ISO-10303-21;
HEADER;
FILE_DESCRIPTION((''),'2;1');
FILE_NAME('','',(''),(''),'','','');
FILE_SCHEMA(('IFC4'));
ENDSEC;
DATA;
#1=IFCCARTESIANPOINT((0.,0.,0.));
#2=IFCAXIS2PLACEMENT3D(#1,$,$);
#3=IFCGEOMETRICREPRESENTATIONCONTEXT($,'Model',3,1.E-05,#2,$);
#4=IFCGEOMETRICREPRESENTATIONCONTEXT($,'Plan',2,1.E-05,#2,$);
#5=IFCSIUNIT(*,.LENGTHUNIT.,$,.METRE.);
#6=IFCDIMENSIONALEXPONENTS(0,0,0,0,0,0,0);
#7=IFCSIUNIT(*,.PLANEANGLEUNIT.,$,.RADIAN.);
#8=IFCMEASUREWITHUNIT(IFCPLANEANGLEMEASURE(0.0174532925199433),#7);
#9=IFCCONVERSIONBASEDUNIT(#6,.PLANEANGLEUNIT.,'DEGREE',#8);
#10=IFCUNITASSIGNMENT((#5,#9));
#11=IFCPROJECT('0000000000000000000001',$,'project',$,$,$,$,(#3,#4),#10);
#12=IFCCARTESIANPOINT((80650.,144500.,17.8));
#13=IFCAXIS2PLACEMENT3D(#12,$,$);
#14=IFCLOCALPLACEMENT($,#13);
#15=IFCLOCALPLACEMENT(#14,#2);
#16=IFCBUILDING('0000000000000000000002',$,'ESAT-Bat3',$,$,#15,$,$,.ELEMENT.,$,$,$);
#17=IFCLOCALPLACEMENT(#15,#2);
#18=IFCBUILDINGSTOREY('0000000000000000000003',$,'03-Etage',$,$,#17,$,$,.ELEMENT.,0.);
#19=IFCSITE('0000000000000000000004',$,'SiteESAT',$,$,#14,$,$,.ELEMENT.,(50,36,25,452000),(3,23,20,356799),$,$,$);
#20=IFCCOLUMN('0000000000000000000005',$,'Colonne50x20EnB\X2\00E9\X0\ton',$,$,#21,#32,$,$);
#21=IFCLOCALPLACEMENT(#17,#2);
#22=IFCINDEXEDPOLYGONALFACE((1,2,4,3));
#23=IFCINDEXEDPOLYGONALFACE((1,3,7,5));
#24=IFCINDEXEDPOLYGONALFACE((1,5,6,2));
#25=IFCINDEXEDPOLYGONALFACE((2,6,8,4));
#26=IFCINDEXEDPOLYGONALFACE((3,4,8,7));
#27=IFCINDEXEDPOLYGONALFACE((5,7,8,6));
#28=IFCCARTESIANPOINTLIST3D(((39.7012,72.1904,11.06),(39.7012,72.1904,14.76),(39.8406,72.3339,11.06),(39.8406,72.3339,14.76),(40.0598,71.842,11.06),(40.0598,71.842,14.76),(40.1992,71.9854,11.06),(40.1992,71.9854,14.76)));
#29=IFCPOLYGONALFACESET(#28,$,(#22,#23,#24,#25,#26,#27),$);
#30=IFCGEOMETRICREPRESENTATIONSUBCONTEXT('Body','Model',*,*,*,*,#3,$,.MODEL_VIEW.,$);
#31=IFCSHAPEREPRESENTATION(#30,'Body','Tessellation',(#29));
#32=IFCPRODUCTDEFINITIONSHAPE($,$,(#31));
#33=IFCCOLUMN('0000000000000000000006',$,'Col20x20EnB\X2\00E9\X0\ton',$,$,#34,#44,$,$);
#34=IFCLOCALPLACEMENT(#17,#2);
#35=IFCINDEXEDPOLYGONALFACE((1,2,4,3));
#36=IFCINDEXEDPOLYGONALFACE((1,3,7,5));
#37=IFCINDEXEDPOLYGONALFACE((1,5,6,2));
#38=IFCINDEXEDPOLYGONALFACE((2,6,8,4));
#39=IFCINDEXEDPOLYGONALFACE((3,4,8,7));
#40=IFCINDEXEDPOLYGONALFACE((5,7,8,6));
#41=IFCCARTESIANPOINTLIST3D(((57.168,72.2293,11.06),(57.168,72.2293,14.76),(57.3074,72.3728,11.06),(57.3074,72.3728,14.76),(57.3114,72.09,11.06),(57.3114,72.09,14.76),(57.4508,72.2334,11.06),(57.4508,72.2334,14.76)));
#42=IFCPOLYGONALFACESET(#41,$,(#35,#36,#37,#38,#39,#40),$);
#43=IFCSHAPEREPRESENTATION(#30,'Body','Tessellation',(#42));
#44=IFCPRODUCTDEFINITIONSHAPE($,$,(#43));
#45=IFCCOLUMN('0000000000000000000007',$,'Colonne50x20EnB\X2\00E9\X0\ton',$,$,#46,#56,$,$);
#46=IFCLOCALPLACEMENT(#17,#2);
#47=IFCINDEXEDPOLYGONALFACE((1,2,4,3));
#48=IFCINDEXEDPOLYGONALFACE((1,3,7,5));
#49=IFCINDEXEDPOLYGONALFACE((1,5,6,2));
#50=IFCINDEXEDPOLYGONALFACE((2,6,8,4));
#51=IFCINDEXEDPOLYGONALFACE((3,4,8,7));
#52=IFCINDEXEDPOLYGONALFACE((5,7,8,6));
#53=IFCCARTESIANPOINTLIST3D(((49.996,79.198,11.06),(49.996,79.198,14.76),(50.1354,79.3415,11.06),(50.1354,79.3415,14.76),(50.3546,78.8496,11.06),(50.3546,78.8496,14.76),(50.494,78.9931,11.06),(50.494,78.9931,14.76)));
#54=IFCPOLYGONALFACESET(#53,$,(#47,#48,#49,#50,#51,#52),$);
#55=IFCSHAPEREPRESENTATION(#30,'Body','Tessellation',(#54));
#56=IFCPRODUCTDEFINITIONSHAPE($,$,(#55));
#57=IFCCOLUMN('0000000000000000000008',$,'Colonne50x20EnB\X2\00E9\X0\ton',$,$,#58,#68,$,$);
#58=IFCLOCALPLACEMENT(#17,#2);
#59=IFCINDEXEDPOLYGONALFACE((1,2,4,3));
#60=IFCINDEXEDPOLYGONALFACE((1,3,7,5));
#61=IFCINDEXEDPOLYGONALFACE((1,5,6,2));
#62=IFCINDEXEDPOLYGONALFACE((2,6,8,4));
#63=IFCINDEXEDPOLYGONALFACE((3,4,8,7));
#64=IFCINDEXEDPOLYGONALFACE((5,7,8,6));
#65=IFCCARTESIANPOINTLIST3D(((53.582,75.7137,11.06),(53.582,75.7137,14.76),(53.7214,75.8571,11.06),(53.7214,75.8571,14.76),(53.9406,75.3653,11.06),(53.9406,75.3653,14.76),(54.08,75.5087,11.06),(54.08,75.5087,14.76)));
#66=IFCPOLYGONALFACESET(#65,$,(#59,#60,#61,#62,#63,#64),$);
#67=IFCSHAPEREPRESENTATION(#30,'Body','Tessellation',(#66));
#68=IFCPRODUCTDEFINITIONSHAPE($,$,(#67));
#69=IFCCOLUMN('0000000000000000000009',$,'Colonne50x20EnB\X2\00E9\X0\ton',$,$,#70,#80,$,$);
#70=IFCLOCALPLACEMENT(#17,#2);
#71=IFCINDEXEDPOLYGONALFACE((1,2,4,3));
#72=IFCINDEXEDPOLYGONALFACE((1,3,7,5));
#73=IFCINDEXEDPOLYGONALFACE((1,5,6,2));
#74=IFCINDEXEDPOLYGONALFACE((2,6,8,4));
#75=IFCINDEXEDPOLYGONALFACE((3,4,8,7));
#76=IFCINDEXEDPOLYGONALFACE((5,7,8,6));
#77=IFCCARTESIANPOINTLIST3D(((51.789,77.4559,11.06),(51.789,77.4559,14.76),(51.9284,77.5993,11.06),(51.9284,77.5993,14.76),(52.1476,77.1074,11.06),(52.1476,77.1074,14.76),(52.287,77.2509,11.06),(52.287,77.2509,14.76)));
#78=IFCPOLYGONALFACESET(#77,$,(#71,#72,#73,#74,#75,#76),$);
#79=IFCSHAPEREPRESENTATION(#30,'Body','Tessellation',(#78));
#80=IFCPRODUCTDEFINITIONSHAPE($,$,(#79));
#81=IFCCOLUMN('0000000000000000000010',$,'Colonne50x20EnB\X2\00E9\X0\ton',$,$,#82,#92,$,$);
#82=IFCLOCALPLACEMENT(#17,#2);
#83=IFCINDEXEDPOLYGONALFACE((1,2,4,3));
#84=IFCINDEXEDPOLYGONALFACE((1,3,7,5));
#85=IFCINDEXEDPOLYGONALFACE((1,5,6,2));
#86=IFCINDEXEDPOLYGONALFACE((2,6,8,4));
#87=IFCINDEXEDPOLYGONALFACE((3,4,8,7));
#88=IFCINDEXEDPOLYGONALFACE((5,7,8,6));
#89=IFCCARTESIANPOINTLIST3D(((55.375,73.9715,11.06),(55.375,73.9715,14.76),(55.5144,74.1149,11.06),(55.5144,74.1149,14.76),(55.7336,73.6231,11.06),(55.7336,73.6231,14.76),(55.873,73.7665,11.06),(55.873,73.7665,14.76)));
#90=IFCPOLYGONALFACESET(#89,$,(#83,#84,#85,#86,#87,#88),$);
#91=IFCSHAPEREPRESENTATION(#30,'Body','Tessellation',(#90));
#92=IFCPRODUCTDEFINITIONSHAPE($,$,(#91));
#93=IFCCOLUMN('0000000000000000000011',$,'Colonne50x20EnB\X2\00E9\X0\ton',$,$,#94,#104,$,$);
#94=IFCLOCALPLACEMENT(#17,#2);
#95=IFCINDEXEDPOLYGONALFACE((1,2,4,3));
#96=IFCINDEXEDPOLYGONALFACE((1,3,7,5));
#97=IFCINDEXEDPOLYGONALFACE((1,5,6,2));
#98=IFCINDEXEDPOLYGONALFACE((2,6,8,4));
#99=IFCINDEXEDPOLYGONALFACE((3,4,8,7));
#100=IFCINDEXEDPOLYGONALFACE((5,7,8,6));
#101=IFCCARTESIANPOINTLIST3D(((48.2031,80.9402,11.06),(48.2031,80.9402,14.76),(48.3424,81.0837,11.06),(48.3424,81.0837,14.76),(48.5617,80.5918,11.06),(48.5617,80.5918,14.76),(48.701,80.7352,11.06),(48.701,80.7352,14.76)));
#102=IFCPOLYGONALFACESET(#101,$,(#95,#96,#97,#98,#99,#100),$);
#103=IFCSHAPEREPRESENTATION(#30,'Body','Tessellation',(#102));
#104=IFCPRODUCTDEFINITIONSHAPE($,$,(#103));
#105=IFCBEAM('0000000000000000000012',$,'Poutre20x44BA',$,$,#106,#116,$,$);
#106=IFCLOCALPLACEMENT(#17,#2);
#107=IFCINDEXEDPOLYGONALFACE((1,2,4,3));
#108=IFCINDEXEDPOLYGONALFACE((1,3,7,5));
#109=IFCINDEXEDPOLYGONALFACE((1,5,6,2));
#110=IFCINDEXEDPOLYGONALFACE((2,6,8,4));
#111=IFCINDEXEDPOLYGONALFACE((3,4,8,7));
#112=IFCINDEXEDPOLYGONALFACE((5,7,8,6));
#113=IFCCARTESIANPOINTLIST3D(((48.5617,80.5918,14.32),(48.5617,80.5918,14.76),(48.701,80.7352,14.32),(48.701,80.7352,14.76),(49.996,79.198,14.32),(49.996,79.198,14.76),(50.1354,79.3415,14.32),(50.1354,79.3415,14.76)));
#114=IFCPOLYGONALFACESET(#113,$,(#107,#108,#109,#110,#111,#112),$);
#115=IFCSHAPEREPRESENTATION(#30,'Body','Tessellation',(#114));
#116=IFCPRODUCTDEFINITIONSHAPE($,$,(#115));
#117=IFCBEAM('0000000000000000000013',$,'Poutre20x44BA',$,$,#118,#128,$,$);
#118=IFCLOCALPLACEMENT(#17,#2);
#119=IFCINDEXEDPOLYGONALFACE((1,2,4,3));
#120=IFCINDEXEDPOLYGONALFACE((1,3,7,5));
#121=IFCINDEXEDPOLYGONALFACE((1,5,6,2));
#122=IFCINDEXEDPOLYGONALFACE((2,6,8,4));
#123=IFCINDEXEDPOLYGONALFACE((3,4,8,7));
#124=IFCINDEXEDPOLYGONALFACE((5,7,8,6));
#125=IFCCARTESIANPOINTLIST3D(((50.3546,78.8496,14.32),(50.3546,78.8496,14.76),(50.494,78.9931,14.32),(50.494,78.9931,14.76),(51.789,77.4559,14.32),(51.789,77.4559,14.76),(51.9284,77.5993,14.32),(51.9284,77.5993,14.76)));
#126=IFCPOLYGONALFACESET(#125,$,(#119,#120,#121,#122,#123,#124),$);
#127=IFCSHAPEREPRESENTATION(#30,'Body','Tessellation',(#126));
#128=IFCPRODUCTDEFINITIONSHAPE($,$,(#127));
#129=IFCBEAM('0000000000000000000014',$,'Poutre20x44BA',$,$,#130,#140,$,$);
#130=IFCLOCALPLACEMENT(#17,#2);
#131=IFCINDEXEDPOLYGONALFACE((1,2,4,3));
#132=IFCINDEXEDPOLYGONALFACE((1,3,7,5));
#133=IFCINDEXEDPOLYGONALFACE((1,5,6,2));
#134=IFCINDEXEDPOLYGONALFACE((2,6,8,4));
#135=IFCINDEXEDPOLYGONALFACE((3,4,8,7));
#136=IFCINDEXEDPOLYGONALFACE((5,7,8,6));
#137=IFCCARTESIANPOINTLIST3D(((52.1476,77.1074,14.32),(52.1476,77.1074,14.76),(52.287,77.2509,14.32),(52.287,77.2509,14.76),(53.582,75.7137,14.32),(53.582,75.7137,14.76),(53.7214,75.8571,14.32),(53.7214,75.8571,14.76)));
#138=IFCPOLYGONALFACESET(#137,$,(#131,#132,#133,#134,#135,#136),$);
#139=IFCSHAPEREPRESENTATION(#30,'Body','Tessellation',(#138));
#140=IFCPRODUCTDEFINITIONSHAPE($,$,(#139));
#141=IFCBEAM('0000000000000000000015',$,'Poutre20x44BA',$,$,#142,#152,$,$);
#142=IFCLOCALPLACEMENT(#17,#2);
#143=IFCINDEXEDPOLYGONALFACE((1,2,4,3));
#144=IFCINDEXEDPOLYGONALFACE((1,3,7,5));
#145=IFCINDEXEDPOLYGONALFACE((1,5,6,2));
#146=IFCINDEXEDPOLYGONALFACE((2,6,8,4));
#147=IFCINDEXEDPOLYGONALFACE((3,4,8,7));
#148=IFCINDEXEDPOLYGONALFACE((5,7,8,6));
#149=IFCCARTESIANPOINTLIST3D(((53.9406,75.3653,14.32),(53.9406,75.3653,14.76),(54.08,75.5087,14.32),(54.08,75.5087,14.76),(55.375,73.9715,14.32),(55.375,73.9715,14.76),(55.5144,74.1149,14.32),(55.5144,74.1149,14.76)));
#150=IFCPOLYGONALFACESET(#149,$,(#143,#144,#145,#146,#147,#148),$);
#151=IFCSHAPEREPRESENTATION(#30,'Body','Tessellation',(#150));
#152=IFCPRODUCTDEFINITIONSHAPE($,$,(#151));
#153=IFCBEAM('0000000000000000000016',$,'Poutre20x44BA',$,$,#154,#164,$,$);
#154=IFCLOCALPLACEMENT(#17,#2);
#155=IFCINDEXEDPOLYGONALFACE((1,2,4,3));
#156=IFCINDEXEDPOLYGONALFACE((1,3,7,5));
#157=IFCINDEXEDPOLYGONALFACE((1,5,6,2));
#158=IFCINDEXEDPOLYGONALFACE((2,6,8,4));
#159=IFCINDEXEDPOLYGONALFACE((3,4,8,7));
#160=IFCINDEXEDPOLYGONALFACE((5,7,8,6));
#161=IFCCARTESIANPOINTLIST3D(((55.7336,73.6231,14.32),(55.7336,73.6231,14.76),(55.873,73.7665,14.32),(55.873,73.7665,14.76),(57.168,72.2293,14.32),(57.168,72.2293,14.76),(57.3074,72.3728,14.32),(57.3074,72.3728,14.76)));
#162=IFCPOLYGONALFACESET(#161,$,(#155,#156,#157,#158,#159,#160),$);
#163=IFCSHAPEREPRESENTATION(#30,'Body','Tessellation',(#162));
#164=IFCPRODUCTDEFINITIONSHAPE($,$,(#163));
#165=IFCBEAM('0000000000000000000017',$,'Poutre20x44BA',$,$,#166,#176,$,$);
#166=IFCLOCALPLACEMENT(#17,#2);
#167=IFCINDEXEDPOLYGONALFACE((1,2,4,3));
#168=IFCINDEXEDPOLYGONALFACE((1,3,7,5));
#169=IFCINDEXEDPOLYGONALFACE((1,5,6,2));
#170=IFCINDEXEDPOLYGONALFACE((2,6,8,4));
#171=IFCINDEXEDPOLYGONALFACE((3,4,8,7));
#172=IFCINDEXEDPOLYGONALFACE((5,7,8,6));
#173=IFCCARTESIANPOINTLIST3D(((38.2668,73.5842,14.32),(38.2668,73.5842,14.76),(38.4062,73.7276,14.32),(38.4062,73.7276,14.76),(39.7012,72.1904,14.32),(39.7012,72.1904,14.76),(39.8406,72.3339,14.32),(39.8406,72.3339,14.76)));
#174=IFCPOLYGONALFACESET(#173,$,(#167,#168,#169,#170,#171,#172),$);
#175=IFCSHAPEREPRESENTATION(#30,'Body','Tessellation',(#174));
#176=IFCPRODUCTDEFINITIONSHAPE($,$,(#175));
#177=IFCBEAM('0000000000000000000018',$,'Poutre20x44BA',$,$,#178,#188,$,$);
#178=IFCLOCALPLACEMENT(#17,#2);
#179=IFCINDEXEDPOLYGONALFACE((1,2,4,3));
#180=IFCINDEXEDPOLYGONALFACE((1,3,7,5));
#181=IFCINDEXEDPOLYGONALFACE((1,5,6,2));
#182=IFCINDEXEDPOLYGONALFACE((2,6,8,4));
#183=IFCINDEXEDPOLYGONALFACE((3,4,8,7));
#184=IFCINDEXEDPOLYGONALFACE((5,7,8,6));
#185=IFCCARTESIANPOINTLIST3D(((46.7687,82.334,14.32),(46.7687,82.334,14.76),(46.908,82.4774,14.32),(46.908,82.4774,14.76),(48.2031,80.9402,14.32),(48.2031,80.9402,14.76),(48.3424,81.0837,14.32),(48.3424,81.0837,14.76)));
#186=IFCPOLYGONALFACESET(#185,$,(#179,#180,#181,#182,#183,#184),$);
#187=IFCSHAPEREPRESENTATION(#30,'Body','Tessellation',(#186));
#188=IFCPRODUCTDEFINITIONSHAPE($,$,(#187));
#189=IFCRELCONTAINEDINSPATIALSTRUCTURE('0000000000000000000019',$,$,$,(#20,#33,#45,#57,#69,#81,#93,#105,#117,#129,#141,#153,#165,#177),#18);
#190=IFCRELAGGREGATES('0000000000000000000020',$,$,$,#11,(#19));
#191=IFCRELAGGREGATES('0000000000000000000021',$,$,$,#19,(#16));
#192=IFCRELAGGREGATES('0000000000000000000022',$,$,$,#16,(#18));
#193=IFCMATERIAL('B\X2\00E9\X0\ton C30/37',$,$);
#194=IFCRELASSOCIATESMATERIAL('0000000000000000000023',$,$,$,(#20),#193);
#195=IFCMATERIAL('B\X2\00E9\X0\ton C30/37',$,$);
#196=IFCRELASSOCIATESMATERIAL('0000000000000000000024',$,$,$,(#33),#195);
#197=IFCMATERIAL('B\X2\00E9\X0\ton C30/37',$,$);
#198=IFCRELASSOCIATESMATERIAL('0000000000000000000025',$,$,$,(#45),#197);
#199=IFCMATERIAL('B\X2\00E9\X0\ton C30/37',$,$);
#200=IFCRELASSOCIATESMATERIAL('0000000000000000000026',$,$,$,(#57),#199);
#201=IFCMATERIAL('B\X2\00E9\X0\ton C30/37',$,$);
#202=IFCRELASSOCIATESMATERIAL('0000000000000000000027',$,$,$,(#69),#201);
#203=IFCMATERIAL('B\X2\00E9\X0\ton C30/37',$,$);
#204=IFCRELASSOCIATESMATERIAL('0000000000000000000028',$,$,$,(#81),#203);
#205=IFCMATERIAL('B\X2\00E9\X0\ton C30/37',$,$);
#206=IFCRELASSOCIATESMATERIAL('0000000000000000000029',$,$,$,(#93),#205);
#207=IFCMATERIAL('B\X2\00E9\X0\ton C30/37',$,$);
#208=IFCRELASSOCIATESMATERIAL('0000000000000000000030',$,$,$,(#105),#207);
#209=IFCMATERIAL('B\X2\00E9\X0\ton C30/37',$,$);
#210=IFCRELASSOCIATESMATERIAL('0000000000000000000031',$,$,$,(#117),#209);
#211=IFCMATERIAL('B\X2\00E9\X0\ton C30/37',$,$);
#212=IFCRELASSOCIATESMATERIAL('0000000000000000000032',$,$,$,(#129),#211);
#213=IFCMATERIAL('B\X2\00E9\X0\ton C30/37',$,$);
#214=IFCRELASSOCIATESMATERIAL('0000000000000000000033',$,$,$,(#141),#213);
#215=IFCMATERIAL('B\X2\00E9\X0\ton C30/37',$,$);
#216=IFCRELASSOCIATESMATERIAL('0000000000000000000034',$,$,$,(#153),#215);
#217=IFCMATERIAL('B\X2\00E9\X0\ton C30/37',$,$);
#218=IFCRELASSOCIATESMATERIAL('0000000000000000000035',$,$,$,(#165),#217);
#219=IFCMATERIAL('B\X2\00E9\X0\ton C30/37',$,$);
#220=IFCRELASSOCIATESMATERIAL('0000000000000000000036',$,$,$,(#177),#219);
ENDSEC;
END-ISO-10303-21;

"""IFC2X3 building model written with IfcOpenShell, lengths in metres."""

from ifc_helpers import new_model, entity, si_unit, converted_unit, frame, frame_2d, origin, origin_with_axes, place, context, subcontext, project, spatial, rectangle, extrude, material, element, save


model = new_model("IFC2X3")

# Units and contexts
model_context = context("Model", 3, precision=1e-05, world=origin())
plan_context = context("Plan", 2, precision=1e-05, world=origin())
body_context = subcontext(model_context, "Body", "Model", "MODEL_VIEW")
ifc_project = project(units=[si_unit("LENGTHUNIT", "METRE"), converted_unit("PLANEANGLEUNIT", "DEGREE", entity("IfcPlaneAngleMeasure", 0.0174532925199433), si_unit("PLANEANGLEUNIT", "RADIAN"), dimensions=[0, 0, 0, 0, 0, 0, 0])], contexts=[model_context, plan_context])

# Site, building, storey
site_placement = place(None, frame((80650.0, 144500.0, 17.8)))
site = spatial("IfcSite", under=ifc_project, at=site_placement, Name="SiteESAT", CompositionType="ELEMENT", RefLatitude=(50, 36, 25, 452000), RefLongitude=(3, 23, 20, 356799))
building_placement = place(site_placement, origin())
building = spatial("IfcBuilding", under=site, at=building_placement, Name="ESAT-Bat3", CompositionType="ELEMENT")
storey_placement = place(building_placement, origin())
storey = spatial("IfcBuildingStorey", under=building, at=storey_placement, Name="03-Etage", CompositionType="ELEMENT", Elevation=0.0)

# Columns
ifc_material_1 = material(Name="Béton C30/37")
column_1_placement = place(storey_placement, frame((40.1992, 71.9854, 11.06)))
element("IfcColumn", 1, at=column_1_placement, inside=storey, material=ifc_material_1, Name="Colonne50x20EnBéton", context=body_context, shape_type="SweptSolid", body=[
    extrude(rectangle(XDim=0.5, YDim=0.2, at=frame_2d((-0.249, 0.1025), x_axis=(-0.717196, 0.696872))), origin_with_axes(), (0.0, 0.0, 1.0), 3.7),
])
ifc_material_2 = material(Name="Béton C30/37")
column_2_placement = place(storey_placement, frame((57.3114, 72.09, 11.06)))
element("IfcColumn", 2, at=column_2_placement, inside=storey, material=ifc_material_2, Name="Col20x20EnBéton", context=body_context, shape_type="SweptSolid", body=[
    extrude(rectangle(XDim=0.2, YDim=0.2, at=frame_2d((-0.002, 0.1414), x_axis=(0.696872, 0.717196))), origin_with_axes(), (0.0, 0.0, 1.0), 3.7),
])
ifc_material_3 = material(Name="Béton C30/37")
column_3_placement = place(storey_placement, frame((50.494, 78.9931, 11.06)))
element("IfcColumn", 3, at=column_3_placement, inside=storey, material=ifc_material_3, Name="Colonne50x20EnBéton", context=body_context, shape_type="SweptSolid", body=[
    extrude(rectangle(XDim=0.5, YDim=0.2, at=frame_2d((-0.249, 0.1025), x_axis=(-0.717196, 0.696872))), origin_with_axes(), (0.0, 0.0, 1.0), 3.7),
])
ifc_material_4 = material(Name="Béton C30/37")
column_4_placement = place(storey_placement, frame((54.08, 75.5087, 11.06)))
element("IfcColumn", 4, at=column_4_placement, inside=storey, material=ifc_material_4, Name="Colonne50x20EnBéton", context=body_context, shape_type="SweptSolid", body=[
    extrude(rectangle(XDim=0.5, YDim=0.2, at=frame_2d((-0.249, 0.1025), x_axis=(-0.717196, 0.696872))), origin_with_axes(), (0.0, 0.0, 1.0), 3.7),
])
ifc_material_5 = material(Name="Béton C30/37")
column_5_placement = place(storey_placement, frame((52.287, 77.2509, 11.06)))
element("IfcColumn", 5, at=column_5_placement, inside=storey, material=ifc_material_5, Name="Colonne50x20EnBéton", context=body_context, shape_type="SweptSolid", body=[
    extrude(rectangle(XDim=0.5, YDim=0.2, at=frame_2d((-0.249, 0.1025), x_axis=(-0.717196, 0.696872))), origin_with_axes(), (0.0, 0.0, 1.0), 3.7),
])
ifc_material_6 = material(Name="Béton C30/37")
column_6_placement = place(storey_placement, frame((55.873, 73.7665, 11.06)))
element("IfcColumn", 6, at=column_6_placement, inside=storey, material=ifc_material_6, Name="Colonne50x20EnBéton", context=body_context, shape_type="SweptSolid", body=[
    extrude(rectangle(XDim=0.5, YDim=0.2, at=frame_2d((-0.249, 0.1025), x_axis=(-0.717196, 0.696872))), origin_with_axes(), (0.0, 0.0, 1.0), 3.7),
])
ifc_material_7 = material(Name="Béton C30/37")
column_7_placement = place(storey_placement, frame((48.701, 80.7352, 11.06)))
element("IfcColumn", 7, at=column_7_placement, inside=storey, material=ifc_material_7, Name="Colonne50x20EnBéton", context=body_context, shape_type="SweptSolid", body=[
    extrude(rectangle(XDim=0.5, YDim=0.2, at=frame_2d((-0.249, 0.1025), x_axis=(-0.717196, 0.696872))), origin_with_axes(), (0.0, 0.0, 1.0), 3.7),
])

# Beams
ifc_material_8 = material(Name="Béton C30/37")
beam_1_placement = place(storey_placement, frame((50.1354, 79.3415, 14.32), z_axis=(0.0, 0.0, 1.0), x_axis=(-0.717196, 0.696872, 0.0)))
element("IfcBeam", 8, at=beam_1_placement, inside=storey, material=ifc_material_8, Name="Poutre20x44BA", context=body_context, shape_type="SweptSolid", body=[
    extrude(rectangle(XDim=0.2, YDim=0.44, at=frame_2d((0.1, 0.22), x_axis=(1.0, 0.0))), frame((0.0, 0.0, 0.0), z_axis=(1.0, 0.0, 0.0), x_axis=(0.0, 1.0, 0.0)), (0.0, 0.0, 1.0), 2.0),
])
ifc_material_9 = material(Name="Béton C30/37")
beam_2_placement = place(storey_placement, frame((51.9284, 77.5993, 14.32), z_axis=(0.0, 0.0, 1.0), x_axis=(-0.717196, 0.696872, 0.0)))
element("IfcBeam", 9, at=beam_2_placement, inside=storey, material=ifc_material_9, Name="Poutre20x44BA", context=body_context, shape_type="SweptSolid", body=[
    extrude(rectangle(XDim=0.2, YDim=0.44, at=frame_2d((0.1, 0.22), x_axis=(1.0, 0.0))), frame((0.0, 0.0, 0.0), z_axis=(1.0, 0.0, 0.0), x_axis=(0.0, 1.0, 0.0)), (0.0, 0.0, 1.0), 2.0),
])
ifc_material_10 = material(Name="Béton C30/37")
beam_3_placement = place(storey_placement, frame((53.7214, 75.8571, 14.32), z_axis=(0.0, 0.0, 1.0), x_axis=(-0.717196, 0.696872, 0.0)))
element("IfcBeam", 10, at=beam_3_placement, inside=storey, material=ifc_material_10, Name="Poutre20x44BA", context=body_context, shape_type="SweptSolid", body=[
    extrude(rectangle(XDim=0.2, YDim=0.44, at=frame_2d((0.1, 0.22), x_axis=(1.0, 0.0))), frame((0.0, 0.0, 0.0), z_axis=(1.0, 0.0, 0.0), x_axis=(0.0, 1.0, 0.0)), (0.0, 0.0, 1.0), 2.0),
])
ifc_material_11 = material(Name="Béton C30/37")
beam_4_placement = place(storey_placement, frame((55.5144, 74.1149, 14.32), z_axis=(0.0, 0.0, 1.0), x_axis=(-0.717196, 0.696872, 0.0)))
element("IfcBeam", 11, at=beam_4_placement, inside=storey, material=ifc_material_11, Name="Poutre20x44BA", context=body_context, shape_type="SweptSolid", body=[
    extrude(rectangle(XDim=0.2, YDim=0.44, at=frame_2d((0.1, 0.22), x_axis=(1.0, 0.0))), frame((0.0, 0.0, 0.0), z_axis=(1.0, 0.0, 0.0), x_axis=(0.0, 1.0, 0.0)), (0.0, 0.0, 1.0), 2.0),
])
ifc_material_12 = material(Name="Béton C30/37")
beam_5_placement = place(storey_placement, frame((57.3074, 72.3728, 14.32), z_axis=(0.0, 0.0, 1.0), x_axis=(-0.717196, 0.696872, 0.0)))
element("IfcBeam", 12, at=beam_5_placement, inside=storey, material=ifc_material_12, Name="Poutre20x44BA", context=body_context, shape_type="SweptSolid", body=[
    extrude(rectangle(XDim=0.2, YDim=0.44, at=frame_2d((0.1, 0.22), x_axis=(1.0, 0.0))), frame((0.0, 0.0, 0.0), z_axis=(1.0, 0.0, 0.0), x_axis=(0.0, 1.0, 0.0)), (0.0, 0.0, 1.0), 2.0),
])
ifc_material_13 = material(Name="Béton C30/37")
beam_6_placement = place(storey_placement, frame((39.8406, 72.3339, 14.32), z_axis=(0.0, 0.0, 1.0), x_axis=(-0.717196, 0.696872, 0.0)))
element("IfcBeam", 13, at=beam_6_placement, inside=storey, material=ifc_material_13, Name="Poutre20x44BA", context=body_context, shape_type="SweptSolid", body=[
    extrude(rectangle(XDim=0.2, YDim=0.44, at=frame_2d((0.1, 0.22), x_axis=(1.0, 0.0))), frame((0.0, 0.0, 0.0), z_axis=(1.0, 0.0, 0.0), x_axis=(0.0, 1.0, 0.0)), (0.0, 0.0, 1.0), 2.0),
])
ifc_material_14 = material(Name="Béton C30/37")
beam_7_placement = place(storey_placement, frame((48.3424, 81.0837, 14.32), z_axis=(0.0, 0.0, 1.0), x_axis=(-0.717196, 0.696872, 0.0)))
element("IfcBeam", 14, at=beam_7_placement, inside=storey, material=ifc_material_14, Name="Poutre20x44BA", context=body_context, shape_type="SweptSolid", body=[
    extrude(rectangle(XDim=0.2, YDim=0.44, at=frame_2d((0.1, 0.22), x_axis=(1.0, 0.0))), frame((0.0, 0.0, 0.0), z_axis=(1.0, 0.0, 0.0), x_axis=(0.0, 1.0, 0.0)), (0.0, 0.0, 1.0), 2.0),
])

save(model, "model.ifc")
